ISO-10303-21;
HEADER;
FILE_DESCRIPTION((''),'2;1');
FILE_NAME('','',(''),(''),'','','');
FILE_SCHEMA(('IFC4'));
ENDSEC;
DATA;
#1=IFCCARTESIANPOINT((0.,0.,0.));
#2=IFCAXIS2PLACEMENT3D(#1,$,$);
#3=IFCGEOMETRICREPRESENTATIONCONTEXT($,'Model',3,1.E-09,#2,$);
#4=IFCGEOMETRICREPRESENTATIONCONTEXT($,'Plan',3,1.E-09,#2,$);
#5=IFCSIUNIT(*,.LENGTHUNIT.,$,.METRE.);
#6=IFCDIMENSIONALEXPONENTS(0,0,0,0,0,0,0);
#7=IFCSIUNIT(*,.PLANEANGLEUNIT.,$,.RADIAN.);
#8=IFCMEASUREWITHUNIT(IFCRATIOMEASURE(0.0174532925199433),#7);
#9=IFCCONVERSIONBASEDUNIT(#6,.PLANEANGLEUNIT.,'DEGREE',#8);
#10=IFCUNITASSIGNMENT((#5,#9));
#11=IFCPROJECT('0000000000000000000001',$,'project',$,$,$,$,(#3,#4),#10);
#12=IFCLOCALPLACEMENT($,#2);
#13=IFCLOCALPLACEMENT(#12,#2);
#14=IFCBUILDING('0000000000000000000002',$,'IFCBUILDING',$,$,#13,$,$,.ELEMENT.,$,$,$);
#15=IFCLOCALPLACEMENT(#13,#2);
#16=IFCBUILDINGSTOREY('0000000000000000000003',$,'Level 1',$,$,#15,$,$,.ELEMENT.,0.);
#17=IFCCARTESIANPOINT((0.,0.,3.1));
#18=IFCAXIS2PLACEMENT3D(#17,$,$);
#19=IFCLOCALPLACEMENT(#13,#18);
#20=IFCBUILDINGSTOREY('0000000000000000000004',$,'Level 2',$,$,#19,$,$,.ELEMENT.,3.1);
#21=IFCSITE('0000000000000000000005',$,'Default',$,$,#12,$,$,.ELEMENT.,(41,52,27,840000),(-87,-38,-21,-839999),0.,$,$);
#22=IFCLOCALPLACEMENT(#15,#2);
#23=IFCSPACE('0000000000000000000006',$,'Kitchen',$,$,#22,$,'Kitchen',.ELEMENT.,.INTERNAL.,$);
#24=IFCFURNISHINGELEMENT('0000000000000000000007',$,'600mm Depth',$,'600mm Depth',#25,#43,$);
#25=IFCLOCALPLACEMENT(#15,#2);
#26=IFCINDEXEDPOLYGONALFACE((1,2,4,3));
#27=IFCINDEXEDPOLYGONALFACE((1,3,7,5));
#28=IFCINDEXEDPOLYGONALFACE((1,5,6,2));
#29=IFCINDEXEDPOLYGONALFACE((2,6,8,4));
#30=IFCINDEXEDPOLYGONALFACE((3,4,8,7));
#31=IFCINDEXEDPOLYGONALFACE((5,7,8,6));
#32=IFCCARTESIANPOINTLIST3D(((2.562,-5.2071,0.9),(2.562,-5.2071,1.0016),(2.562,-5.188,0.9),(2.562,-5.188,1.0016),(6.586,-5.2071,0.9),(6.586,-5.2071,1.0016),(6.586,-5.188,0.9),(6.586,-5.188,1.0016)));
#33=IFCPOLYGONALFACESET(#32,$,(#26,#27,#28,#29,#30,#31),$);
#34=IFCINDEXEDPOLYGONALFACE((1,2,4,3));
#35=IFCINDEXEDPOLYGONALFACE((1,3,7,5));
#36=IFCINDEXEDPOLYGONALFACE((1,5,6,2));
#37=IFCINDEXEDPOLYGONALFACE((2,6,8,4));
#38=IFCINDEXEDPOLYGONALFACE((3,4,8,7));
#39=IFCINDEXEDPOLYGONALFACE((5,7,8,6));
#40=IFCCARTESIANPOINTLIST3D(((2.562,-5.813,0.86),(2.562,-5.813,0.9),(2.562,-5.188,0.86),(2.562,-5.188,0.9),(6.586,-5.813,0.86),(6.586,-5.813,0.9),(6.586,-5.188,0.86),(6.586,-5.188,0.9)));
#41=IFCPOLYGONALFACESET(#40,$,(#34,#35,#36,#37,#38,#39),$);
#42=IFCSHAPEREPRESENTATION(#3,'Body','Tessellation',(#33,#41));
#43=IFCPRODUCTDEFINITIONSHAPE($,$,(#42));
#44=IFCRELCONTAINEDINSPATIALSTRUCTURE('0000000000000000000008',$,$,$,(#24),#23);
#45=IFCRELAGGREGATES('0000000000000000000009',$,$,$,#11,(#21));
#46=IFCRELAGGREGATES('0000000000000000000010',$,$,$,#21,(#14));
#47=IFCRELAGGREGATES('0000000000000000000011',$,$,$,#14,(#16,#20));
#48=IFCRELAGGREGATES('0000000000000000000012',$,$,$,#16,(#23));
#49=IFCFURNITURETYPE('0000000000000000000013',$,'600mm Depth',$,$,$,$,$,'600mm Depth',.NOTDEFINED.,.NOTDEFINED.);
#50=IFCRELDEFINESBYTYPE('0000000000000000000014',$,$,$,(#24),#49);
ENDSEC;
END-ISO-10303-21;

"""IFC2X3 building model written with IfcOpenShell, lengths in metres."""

from ifc_helpers import new_model, entity, si_unit, converted_unit, frame, origin, origin_2d_with_axis, place, context, project, spatial, rectangle, extrude, source, transform, mapped, type_object, type_shapes, element, save


model = new_model("IFC2X3")

# Units and contexts
model_context = context("Model", 3, precision=1e-09, world=origin())
plan_context = context("Plan", 3, precision=1e-09, world=origin())
ifc_project = project(units=[si_unit("LENGTHUNIT", "METRE"), converted_unit("PLANEANGLEUNIT", "DEGREE", entity("IfcRatioMeasure", 0.0174532925199433), si_unit("PLANEANGLEUNIT", "RADIAN"), dimensions=[0, 0, 0, 0, 0, 0, 0])], contexts=[model_context, plan_context])

# Site, building, storey
site_placement = place(None, origin())
site = spatial("IfcSite", under=ifc_project, at=site_placement, Name="Default", CompositionType="ELEMENT", RefLatitude=(41, 52, 27, 840000), RefLongitude=(-87, -38, -21, -839999), RefElevation=0.0)
building_placement = place(site_placement, origin())
building = spatial("IfcBuilding", under=site, at=building_placement, Name="IFCBUILDING", CompositionType="ELEMENT")
storey_1_placement = place(building_placement, origin())
storey_1 = spatial("IfcBuildingStorey", under=building, at=storey_1_placement, Name="Level 1", CompositionType="ELEMENT", Elevation=0.0)

# Shared definitions
storey_2_placement = place(building_placement, frame((0.0, 0.0, 3.1)))
storey_2 = spatial("IfcBuildingStorey", under=building, at=storey_2_placement, Name="Level 2", CompositionType="ELEMENT", Elevation=3.1)

# Shared definitions
space_1_placement = place(storey_1_placement, origin())
space_1 = spatial("IfcSpace", under=storey_1, at=space_1_placement, Name="Kitchen", LongName="Kitchen", CompositionType="ELEMENT", InteriorOrExteriorSpace="INTERNAL")

# Furnishing element
furniture_type_1 = type_object("IfcFurnitureType", Name="600mm Depth", ElementType="600mm Depth", AssemblyPlace="NOTDEFINED")
shared_shape_1 = source(origin(), model_context, "Body", "SweptSolid", [
    extrude(rectangle(XDim=0.0191, YDim=4.024, at=origin_2d_with_axis()), frame((0.8115, -0.0095, 0.9), z_axis=(0.0, 0.0, 1.0), x_axis=(0.0, -1.0, 0.0)), (0.0, 0.0, 1.0), 0.1016),
    extrude(rectangle(XDim=4.024, YDim=0.625, at=origin_2d_with_axis()), frame((0.8115, -0.3125, 0.86), z_axis=(0.0, 0.0, 1.0), x_axis=(-1.0, 0.0, 0.0)), (0.0, 0.0, 1.0), 0.04),
])
type_shapes(furniture_type_1, [shared_shape_1])
furnishing_1_placement = place(space_1_placement, frame((3.7625, -5.188, 0.0)))
element("IfcFurnishingElement", 1, at=furnishing_1_placement, inside=space_1, type_object=furniture_type_1, Name="600mm Depth", ObjectType="600mm Depth", context=model_context, shape_type="MappedRepresentation", body=[
    mapped(shared_shape_1, transform((0.0, 0.0, 0.0), scale=1.0)),
])

save(model, "model.ifc")
